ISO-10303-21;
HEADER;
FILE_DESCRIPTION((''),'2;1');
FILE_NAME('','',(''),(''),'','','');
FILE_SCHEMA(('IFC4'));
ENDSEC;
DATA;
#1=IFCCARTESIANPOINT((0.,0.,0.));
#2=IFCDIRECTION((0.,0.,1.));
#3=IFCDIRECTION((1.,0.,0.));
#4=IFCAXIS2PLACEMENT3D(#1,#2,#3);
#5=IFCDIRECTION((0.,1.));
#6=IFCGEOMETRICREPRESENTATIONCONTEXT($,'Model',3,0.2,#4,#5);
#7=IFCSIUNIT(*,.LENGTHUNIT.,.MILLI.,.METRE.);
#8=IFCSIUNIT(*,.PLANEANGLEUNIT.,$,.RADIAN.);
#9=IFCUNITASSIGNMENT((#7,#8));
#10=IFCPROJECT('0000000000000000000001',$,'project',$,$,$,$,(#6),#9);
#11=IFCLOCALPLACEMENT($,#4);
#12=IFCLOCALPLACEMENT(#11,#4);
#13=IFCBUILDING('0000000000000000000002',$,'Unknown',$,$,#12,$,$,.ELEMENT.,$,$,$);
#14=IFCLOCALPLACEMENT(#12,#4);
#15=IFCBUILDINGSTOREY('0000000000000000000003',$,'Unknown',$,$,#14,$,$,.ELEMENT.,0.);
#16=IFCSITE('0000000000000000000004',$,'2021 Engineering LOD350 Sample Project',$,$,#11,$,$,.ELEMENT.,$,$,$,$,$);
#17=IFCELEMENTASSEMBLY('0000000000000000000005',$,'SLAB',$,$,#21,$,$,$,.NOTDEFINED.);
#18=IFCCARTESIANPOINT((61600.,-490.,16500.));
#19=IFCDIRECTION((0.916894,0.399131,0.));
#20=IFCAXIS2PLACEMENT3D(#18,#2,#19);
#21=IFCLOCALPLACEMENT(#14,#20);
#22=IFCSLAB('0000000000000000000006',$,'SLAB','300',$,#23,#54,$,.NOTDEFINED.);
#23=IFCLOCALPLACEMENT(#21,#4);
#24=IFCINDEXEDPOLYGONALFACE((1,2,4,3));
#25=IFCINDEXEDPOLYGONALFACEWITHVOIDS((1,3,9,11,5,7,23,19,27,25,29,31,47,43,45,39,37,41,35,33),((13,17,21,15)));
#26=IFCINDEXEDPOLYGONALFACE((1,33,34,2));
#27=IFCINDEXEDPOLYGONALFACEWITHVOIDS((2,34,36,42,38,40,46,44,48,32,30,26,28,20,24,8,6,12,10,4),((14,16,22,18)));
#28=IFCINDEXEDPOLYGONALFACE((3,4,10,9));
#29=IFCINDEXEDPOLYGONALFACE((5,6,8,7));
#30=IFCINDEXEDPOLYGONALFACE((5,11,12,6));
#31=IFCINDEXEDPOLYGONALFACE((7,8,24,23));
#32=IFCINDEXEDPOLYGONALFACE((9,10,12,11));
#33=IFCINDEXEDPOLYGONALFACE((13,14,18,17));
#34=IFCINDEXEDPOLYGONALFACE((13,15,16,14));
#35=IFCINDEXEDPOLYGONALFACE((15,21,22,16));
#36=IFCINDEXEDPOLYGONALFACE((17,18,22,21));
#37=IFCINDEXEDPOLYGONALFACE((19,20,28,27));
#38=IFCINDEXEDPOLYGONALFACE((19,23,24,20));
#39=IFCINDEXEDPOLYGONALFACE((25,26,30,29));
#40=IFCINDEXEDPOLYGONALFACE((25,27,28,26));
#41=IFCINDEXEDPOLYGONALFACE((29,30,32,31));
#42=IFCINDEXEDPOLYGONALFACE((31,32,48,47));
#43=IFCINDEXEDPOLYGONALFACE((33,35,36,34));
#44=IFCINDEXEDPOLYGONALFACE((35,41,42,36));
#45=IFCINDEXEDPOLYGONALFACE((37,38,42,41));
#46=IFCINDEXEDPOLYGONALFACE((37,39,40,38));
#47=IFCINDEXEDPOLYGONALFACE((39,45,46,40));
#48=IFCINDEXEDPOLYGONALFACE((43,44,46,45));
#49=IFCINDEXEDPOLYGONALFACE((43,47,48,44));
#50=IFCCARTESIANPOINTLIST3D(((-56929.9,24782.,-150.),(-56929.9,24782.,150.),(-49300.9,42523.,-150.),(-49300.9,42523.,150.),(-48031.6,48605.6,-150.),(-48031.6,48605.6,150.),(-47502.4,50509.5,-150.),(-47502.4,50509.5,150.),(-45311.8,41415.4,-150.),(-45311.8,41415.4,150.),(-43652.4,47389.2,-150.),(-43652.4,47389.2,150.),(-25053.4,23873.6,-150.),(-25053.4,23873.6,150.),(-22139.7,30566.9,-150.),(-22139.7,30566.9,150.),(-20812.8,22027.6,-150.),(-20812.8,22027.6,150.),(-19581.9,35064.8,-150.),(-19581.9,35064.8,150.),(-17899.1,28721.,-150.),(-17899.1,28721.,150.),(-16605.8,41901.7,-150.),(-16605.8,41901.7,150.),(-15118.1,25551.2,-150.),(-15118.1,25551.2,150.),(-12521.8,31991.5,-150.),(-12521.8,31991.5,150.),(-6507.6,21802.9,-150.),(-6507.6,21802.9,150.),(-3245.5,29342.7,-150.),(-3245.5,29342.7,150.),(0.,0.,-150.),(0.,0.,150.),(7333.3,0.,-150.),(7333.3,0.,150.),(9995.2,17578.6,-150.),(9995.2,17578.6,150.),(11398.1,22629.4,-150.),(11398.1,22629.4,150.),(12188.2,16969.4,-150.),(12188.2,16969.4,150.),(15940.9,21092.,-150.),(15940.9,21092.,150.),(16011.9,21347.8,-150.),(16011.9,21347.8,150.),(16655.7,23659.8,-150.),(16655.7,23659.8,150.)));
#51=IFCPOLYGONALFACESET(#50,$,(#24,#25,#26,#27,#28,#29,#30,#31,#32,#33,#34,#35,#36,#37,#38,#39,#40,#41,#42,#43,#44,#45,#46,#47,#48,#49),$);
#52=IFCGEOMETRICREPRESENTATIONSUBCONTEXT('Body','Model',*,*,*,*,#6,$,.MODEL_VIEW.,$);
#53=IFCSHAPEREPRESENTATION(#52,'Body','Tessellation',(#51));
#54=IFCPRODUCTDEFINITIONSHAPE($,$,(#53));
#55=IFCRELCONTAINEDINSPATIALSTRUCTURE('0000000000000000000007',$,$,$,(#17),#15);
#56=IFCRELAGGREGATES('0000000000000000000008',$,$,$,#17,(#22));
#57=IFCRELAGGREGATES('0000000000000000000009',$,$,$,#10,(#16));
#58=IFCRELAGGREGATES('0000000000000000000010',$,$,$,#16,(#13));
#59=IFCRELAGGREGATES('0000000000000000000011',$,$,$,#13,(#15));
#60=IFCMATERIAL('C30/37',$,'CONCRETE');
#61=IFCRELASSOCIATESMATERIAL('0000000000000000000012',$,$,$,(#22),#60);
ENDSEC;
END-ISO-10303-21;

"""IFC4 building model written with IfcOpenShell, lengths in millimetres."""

from ifc_helpers import new_model, si_unit, direction, frame, origin_with_axes, place, context, subcontext, project, spatial, line, indexed_curve, outline, extrude, material, element, aggregate, save


model = new_model("IFC4")

# Units and contexts
model_context = context("Model", 3, precision=0.2, world=origin_with_axes(), true_north=direction((0.0, 1.0)))
body_context = subcontext(model_context, "Body", "Model", "MODEL_VIEW")
ifc_project = project(units=[si_unit("LENGTHUNIT", "METRE", prefix="MILLI"), si_unit("PLANEANGLEUNIT", "RADIAN")], contexts=[model_context])

# Site, building, storey
site_placement = place(None, origin_with_axes())
site = spatial("IfcSite", under=ifc_project, at=site_placement, Name="2021 Engineering LOD350 Sample Project", CompositionType="ELEMENT")
building_placement = place(site_placement, origin_with_axes())
building = spatial("IfcBuilding", under=site, at=building_placement, Name="Unknown", CompositionType="ELEMENT")
storey_placement = place(building_placement, origin_with_axes())
storey = spatial("IfcBuildingStorey", under=building, at=storey_placement, Name="Unknown", CompositionType="ELEMENT", Elevation=0.0)

# Element assembly, slab, voiding features
assembly_1_placement = place(storey_placement, frame((61600.0, -490.0, 16500.0), z_axis=(0.0, 0.0, 1.0), x_axis=(0.916894, 0.399131, 0.0)))
assembly_1 = element("IfcElementAssembly", 1, at=assembly_1_placement, inside=storey, Name="SLAB", PredefinedType="NOTDEFINED")
ifc_material_1 = material(Name="C30/37", Category="CONCRETE")
slab_placement = place(assembly_1_placement, origin_with_axes())
slab = element("IfcSlab", 2, at=slab_placement, material=ifc_material_1, Name="SLAB", Description="300", PredefinedType="NOTDEFINED", context=body_context, shape_type="SolidModel", body=[
    extrude(outline(indexed_curve([(0.0, 0.0), (7333.3, 0.0), (12188.2, 16969.4), (14606.2, 16297.8), (16655.7, 23659.8), (-3245.5, 29342.7), (-6507.6, 21802.9), (-15118.1, 25551.2), (-12521.8, 31991.5), (-19581.9, 35064.8), (-16605.8, 41901.7), (-47502.4, 50509.5), (-48031.6, 48605.6), (-43652.4, 47389.2), (-45311.8, 41415.4), (-49300.9, 42523.0), (-56929.9, 24782.0)], segments=[line(1, 2, 3, 4, 5, 6, 7, 8, 9, 10, 11, 12, 13, 14, 15, 16, 17, 1)])), frame((0.0, 0.0, 150.0), z_axis=(0.0, 0.0, 1.0), x_axis=(1.0, 0.0, 0.0)), (0.0, 0.0, -1.0), 300.0),
])
voiding_feature_1_placement = place(slab_placement, frame((-22139.7, 30566.9, -50.0), z_axis=(0.0, 0.0, -1.0), x_axis=(0.916894, -0.399131, 0.0)))
element("IfcVoidingFeature", 3, at=voiding_feature_1_placement, cuts=slab, Name="CUTPART", PredefinedType="HOLE", context=body_context, shape_type="SolidModel", body=[
    extrude(outline(indexed_curve([(0.0, 0.0), (4625.0, 0.0), (4625.0, 7300.0), (0.0, 7300.0)], segments=[line(1, 2, 3, 4, 1)])), frame((0.0, 0.0, 252.5), z_axis=(0.0, 0.0, 1.0), x_axis=(1.0, 0.0, 0.0)), (0.0, 0.0, -1.0), 505.0),
])
voiding_feature_2_placement = place(slab_placement, frame((14609.0, 16297.0, -50.0), z_axis=(0.0, 0.0, -1.0), x_axis=(-0.963519, 0.26764, 0.0)))
element("IfcVoidingFeature", 4, at=voiding_feature_2_placement, cuts=slab, Name="CUTPART", PredefinedType="HOLE", context=body_context, shape_type="SolidModel", body=[
    extrude(outline(indexed_curve([(0.0, 0.0), (4788.5, 0.0), (4788.5, 5242.0), (0.0, 5242.0)], segments=[line(1, 2, 3, 4, 1)])), frame((0.0, 0.0, 252.5), z_axis=(0.0, 0.0, 1.0), x_axis=(1.0, 0.0, 0.0)), (0.0, 0.0, -1.0), 505.0),
])

aggregate(assembly_1, [slab])

save(model, "model.ifc")
